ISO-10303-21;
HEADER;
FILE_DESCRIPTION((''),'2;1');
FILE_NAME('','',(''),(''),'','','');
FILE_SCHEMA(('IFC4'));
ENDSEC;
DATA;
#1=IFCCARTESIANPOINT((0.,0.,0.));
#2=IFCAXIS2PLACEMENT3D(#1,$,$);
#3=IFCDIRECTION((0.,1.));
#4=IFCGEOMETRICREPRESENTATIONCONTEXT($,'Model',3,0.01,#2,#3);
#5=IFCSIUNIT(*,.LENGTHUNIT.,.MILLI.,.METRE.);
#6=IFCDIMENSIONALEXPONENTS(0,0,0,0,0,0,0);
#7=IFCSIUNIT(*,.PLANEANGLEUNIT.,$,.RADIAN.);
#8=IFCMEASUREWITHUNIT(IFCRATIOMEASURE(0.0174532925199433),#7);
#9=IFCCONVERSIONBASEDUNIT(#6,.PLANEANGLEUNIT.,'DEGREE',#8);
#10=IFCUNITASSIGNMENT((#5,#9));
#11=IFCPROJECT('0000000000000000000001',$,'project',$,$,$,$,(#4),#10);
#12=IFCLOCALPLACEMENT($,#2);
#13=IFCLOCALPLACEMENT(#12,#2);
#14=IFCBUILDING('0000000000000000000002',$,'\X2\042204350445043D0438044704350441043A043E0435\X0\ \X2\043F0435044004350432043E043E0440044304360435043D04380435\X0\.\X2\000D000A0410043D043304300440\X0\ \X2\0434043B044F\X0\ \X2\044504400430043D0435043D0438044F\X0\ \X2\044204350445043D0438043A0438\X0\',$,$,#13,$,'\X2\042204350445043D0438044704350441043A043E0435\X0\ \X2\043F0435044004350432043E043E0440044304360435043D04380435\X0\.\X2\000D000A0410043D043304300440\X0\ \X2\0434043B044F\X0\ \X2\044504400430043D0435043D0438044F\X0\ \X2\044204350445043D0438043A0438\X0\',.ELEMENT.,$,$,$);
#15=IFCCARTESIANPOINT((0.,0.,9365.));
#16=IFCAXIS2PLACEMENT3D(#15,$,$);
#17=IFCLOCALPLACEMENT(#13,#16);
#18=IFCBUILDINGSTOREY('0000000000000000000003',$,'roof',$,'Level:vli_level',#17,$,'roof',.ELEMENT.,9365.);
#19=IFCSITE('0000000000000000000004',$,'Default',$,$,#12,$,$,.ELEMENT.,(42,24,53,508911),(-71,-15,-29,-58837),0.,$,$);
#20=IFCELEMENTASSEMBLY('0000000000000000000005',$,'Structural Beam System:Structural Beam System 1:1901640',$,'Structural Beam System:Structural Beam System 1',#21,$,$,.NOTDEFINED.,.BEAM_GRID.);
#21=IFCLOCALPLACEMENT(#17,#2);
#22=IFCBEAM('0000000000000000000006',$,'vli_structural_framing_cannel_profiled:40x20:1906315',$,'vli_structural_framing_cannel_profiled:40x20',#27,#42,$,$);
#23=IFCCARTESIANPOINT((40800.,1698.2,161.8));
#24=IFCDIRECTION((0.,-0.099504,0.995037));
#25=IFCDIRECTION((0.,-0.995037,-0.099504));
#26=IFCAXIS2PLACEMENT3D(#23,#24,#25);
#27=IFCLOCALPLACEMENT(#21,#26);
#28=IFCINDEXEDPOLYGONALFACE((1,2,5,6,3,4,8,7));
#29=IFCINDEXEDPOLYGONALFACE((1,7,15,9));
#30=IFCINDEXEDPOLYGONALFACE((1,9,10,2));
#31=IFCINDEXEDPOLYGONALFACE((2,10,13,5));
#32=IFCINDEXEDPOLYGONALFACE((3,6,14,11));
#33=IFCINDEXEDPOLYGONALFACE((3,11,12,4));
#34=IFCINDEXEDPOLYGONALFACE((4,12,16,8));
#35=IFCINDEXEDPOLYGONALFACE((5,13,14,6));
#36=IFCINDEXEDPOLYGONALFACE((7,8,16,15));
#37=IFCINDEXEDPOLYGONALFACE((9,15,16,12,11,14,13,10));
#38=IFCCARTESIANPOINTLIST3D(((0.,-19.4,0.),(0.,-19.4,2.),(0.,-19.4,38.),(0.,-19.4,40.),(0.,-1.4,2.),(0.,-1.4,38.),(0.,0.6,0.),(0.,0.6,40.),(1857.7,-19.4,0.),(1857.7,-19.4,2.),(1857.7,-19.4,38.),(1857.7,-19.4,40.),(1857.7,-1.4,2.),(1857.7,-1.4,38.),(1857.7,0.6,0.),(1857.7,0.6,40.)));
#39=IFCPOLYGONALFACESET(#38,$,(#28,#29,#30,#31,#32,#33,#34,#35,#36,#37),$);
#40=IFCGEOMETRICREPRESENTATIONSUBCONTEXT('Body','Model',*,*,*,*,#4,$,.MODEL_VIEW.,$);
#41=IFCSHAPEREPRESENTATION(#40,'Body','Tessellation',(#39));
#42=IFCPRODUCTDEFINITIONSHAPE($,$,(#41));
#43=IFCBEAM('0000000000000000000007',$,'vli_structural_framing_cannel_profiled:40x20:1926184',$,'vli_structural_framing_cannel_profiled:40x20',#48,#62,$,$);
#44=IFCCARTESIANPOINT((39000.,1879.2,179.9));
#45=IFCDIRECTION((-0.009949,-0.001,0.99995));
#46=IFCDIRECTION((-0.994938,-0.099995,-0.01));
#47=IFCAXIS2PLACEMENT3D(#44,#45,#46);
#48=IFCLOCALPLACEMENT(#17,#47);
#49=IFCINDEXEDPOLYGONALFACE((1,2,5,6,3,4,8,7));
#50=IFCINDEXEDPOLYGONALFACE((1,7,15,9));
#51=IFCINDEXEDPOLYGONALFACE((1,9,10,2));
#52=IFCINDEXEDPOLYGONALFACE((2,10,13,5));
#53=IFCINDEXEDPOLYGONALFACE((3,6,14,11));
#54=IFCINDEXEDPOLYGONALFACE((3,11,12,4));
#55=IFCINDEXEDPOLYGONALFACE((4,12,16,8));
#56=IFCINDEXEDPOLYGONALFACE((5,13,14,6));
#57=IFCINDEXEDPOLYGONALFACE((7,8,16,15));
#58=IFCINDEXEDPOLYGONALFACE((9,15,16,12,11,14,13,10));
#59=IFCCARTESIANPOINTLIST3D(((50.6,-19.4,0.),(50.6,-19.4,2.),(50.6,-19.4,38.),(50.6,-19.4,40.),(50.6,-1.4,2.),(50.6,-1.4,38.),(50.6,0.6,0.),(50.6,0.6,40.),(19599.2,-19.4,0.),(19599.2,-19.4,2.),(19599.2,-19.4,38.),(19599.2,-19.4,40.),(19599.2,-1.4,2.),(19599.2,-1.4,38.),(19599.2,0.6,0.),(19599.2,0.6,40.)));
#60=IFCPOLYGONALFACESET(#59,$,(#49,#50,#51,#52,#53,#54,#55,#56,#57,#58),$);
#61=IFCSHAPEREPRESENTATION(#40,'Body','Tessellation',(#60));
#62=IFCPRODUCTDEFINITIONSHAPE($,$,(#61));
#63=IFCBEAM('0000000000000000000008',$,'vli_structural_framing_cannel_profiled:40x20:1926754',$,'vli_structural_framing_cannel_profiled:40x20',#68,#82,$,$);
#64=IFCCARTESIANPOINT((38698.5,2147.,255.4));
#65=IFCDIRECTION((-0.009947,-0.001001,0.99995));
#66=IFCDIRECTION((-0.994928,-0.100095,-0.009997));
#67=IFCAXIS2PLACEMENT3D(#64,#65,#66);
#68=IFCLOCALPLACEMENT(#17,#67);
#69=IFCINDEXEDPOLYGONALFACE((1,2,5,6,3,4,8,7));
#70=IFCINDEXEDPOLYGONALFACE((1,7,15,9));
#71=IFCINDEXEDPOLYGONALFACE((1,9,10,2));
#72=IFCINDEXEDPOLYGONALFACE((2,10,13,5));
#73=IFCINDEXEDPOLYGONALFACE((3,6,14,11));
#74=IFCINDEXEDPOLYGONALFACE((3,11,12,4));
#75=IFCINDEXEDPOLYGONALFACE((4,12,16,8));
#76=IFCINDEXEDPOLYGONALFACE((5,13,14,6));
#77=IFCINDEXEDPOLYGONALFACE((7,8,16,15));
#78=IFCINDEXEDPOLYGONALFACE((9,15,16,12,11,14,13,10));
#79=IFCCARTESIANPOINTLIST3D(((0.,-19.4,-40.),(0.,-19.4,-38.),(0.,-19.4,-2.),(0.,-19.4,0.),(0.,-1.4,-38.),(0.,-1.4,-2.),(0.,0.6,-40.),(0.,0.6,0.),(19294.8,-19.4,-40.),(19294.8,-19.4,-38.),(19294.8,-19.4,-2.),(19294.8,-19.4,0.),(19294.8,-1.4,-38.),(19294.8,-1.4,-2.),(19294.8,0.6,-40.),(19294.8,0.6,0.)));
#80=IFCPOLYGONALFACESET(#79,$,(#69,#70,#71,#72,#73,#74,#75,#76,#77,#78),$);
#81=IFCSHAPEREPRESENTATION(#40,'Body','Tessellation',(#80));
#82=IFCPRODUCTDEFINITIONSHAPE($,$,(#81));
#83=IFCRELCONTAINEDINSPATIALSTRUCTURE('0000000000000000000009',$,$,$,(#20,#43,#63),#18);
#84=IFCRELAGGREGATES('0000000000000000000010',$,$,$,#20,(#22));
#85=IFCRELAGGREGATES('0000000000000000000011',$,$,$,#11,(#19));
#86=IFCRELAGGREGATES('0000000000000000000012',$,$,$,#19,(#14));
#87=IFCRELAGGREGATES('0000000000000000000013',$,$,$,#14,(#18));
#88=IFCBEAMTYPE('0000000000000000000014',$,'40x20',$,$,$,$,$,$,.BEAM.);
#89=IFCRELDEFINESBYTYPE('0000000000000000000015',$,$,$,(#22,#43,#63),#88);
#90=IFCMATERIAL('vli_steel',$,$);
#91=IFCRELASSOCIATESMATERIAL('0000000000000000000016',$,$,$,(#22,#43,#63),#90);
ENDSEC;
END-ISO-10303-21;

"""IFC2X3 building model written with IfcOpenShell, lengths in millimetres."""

from ifc_helpers import new_model, entity, si_unit, converted_unit, direction, frame, origin, place, context, subcontext, project, spatial, polyline, outline, extrude, material, type_object, element, aggregate, save


model = new_model("IFC2X3")

# Units and contexts
model_context = context("Model", 3, precision=0.01, world=origin(), true_north=direction((0.0, 1.0)))
body_context = subcontext(model_context, "Body", "Model", "MODEL_VIEW")
ifc_project = project(units=[si_unit("LENGTHUNIT", "METRE", prefix="MILLI"), converted_unit("PLANEANGLEUNIT", "DEGREE", entity("IfcRatioMeasure", 0.0174532925199433), si_unit("PLANEANGLEUNIT", "RADIAN"), dimensions=[0, 0, 0, 0, 0, 0, 0])], contexts=[model_context])

# Site, building, storey
site_placement = place(None, origin())
site = spatial("IfcSite", under=ifc_project, at=site_placement, Name="Default", CompositionType="ELEMENT", RefLatitude=(42, 24, 53, 508911), RefLongitude=(-71, -15, -29, -58837), RefElevation=0.0)
building_placement = place(site_placement, origin())
building = spatial("IfcBuilding", under=site, at=building_placement, Name="Техническое перевооружение.\r\nАнгар для хранения техники", LongName="Техническое перевооружение.\r\nАнгар для хранения техники", CompositionType="ELEMENT")
storey_placement = place(building_placement, frame((0.0, 0.0, 9365.0)))
storey = spatial("IfcBuildingStorey", under=building, at=storey_placement, Name="roof", ObjectType="Level:vli_level", LongName="roof", CompositionType="ELEMENT", Elevation=9365.0)

# Element assembly, beam
assembly_1_placement = place(storey_placement, origin())
assembly_1 = element("IfcElementAssembly", 1, at=assembly_1_placement, inside=storey, Name="Structural Beam System:Structural Beam System 1:1901640", ObjectType="Structural Beam System:Structural Beam System 1", AssemblyPlace="NOTDEFINED", PredefinedType="BEAM_GRID")
ifc_material = material(Name="vli_steel")
beam_type = type_object("IfcBeamType", Name="40x20", PredefinedType="BEAM")
beam_1_placement = place(assembly_1_placement, frame((40800.0, 1698.2, 161.8), z_axis=(0.0, -0.099504, 0.995037), x_axis=(0.0, -0.995037, -0.099504)))
beam_1 = element("IfcBeam", 2, at=beam_1_placement, type_object=beam_type, material=ifc_material, Name="vli_structural_framing_cannel_profiled:40x20:1906315", ObjectType="vli_structural_framing_cannel_profiled:40x20", context=body_context, shape_type="SweptSolid", body=[
    extrude(outline(polyline([(-20.0, -9.5), (-18.0, -9.5), (-18.0, 8.5), (18.0, 8.5), (18.0, -9.5), (20.0, -9.5), (20.0, 10.5), (-20.0, 10.5), (-20.0, -9.5)])), frame((0.0, -9.9, 20.0), z_axis=(1.0, 0.0, 0.0), x_axis=(0.0, 0.0, -1.0)), (0.0, 0.0, 1.0), 1857.7),
])
aggregate(assembly_1, [beam_1])

# Beams
beam_2_placement = place(storey_placement, frame((39000.0, 1879.2, 179.9), z_axis=(-0.009949, -0.001, 0.99995), x_axis=(-0.994938, -0.099995, -0.01)))
element("IfcBeam", 3, at=beam_2_placement, inside=storey, type_object=beam_type, material=ifc_material, Name="vli_structural_framing_cannel_profiled:40x20:1926184", ObjectType="vli_structural_framing_cannel_profiled:40x20", context=body_context, shape_type="SweptSolid", body=[
    extrude(outline(polyline([(-20.0, -9.5), (-18.0, -9.5), (-18.0, 8.5), (18.0, 8.5), (18.0, -9.5), (20.0, -9.5), (20.0, 10.5), (-20.0, 10.5), (-20.0, -9.5)])), frame((50.6, -9.9, 20.0), z_axis=(1.0, 0.0, 0.0), x_axis=(0.0, 0.0, -1.0)), (0.0, 0.0, 1.0), 19548.6),
])
beam_3_placement = place(storey_placement, frame((38698.5, 2147.0, 255.4), z_axis=(-0.009947, -0.001001, 0.99995), x_axis=(-0.994928, -0.100095, -0.009997)))
element("IfcBeam", 4, at=beam_3_placement, inside=storey, type_object=beam_type, material=ifc_material, Name="vli_structural_framing_cannel_profiled:40x20:1926754", ObjectType="vli_structural_framing_cannel_profiled:40x20", context=body_context, shape_type="SweptSolid", body=[
    extrude(outline(polyline([(-20.0, -9.5), (-18.0, -9.5), (-18.0, 8.5), (18.0, 8.5), (18.0, -9.5), (20.0, -9.5), (20.0, 10.5), (-20.0, 10.5), (-20.0, -9.5)])), frame((0.0, -9.9, -20.0), z_axis=(1.0, 0.0, 0.0), x_axis=(0.0, 0.0, -1.0)), (0.0, 0.0, 1.0), 19294.8),
])

save(model, "model.ifc")
